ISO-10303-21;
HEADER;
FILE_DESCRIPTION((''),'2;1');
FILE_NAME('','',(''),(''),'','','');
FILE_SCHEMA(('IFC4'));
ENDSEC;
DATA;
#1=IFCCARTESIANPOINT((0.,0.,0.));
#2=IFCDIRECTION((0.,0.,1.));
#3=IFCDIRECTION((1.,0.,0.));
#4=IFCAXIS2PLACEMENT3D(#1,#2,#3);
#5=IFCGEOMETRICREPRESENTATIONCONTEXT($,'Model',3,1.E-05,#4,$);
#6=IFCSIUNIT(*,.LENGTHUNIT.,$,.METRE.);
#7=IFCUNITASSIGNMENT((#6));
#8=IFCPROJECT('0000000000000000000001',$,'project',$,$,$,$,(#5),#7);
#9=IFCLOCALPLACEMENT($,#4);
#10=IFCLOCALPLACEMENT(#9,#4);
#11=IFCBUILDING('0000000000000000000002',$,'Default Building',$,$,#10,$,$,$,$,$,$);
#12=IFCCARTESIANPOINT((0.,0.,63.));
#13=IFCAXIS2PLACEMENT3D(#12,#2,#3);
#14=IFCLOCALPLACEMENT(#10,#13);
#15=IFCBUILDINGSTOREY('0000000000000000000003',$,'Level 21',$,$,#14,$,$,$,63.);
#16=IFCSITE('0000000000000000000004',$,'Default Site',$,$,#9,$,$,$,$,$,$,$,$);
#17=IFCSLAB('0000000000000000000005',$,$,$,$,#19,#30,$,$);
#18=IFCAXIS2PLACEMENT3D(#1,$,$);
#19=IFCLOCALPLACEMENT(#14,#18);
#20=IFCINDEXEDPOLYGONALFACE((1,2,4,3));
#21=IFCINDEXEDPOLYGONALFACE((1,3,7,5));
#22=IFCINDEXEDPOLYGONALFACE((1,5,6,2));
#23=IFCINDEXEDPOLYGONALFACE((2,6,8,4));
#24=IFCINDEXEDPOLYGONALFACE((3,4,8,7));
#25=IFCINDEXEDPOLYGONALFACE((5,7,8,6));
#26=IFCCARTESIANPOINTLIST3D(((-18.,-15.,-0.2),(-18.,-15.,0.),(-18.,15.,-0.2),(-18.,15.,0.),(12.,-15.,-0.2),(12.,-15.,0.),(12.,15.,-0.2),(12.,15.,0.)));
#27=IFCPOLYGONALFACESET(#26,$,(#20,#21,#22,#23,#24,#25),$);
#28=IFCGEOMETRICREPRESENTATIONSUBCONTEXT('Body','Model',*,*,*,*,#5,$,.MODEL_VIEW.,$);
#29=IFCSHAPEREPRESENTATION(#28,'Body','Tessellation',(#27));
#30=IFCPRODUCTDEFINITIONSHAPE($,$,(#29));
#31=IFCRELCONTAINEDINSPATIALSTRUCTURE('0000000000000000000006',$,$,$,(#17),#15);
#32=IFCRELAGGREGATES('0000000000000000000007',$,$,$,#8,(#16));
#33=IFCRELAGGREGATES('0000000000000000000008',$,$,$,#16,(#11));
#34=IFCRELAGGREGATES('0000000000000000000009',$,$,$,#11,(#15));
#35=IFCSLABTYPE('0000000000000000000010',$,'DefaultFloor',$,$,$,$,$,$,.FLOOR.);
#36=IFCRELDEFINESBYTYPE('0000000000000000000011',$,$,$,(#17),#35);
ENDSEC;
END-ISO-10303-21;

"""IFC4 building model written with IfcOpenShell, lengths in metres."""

from ifc_helpers import new_model, si_unit, frame, origin_with_axes, place, context, subcontext, project, spatial, polyline, outline, extrude, type_object, element, save


model = new_model("IFC4")

# Units and contexts
model_context = context("Model", 3, precision=1e-05, world=origin_with_axes())
body_context = subcontext(model_context, "Body", "Model", "MODEL_VIEW")
ifc_project = project(units=[si_unit("LENGTHUNIT", "METRE")], contexts=[model_context])

# Site, building, storey
site_placement = place(None, origin_with_axes())
site = spatial("IfcSite", under=ifc_project, at=site_placement, Name="Default Site")
building_placement = place(site_placement, origin_with_axes())
building = spatial("IfcBuilding", under=site, at=building_placement, Name="Default Building")
storey_placement = place(building_placement, frame((0.0, 0.0, 63.0), z_axis=(0.0, 0.0, 1.0), x_axis=(1.0, 0.0, 0.0)))
storey = spatial("IfcBuildingStorey", under=building, at=storey_placement, Name="Level 21", Elevation=63.0)

# Slab
slab_type = type_object("IfcSlabType", Name="DefaultFloor", PredefinedType="FLOOR")
slab_placement = place(storey_placement, frame((0.0, 0.0, -63.0), z_axis=(0.0, 0.0, 1.0), x_axis=(1.0, 0.0, 0.0)))
element("IfcSlab", 1, at=slab_placement, inside=storey, type_object=slab_type, context=body_context, shape_type="SweptSolid", body=[
    extrude(outline(polyline([(-18.0, 15.0), (12.0, 15.0), (12.0, -15.0), (-18.0, -15.0), (-18.0, 15.0)])), frame((0.0, 0.0, 63.0), z_axis=(0.0, 0.0, 1.0), x_axis=(1.0, 0.0, 0.0)), (0.0, 0.0, -1.0), 0.2),
])

save(model, "model.ifc")
